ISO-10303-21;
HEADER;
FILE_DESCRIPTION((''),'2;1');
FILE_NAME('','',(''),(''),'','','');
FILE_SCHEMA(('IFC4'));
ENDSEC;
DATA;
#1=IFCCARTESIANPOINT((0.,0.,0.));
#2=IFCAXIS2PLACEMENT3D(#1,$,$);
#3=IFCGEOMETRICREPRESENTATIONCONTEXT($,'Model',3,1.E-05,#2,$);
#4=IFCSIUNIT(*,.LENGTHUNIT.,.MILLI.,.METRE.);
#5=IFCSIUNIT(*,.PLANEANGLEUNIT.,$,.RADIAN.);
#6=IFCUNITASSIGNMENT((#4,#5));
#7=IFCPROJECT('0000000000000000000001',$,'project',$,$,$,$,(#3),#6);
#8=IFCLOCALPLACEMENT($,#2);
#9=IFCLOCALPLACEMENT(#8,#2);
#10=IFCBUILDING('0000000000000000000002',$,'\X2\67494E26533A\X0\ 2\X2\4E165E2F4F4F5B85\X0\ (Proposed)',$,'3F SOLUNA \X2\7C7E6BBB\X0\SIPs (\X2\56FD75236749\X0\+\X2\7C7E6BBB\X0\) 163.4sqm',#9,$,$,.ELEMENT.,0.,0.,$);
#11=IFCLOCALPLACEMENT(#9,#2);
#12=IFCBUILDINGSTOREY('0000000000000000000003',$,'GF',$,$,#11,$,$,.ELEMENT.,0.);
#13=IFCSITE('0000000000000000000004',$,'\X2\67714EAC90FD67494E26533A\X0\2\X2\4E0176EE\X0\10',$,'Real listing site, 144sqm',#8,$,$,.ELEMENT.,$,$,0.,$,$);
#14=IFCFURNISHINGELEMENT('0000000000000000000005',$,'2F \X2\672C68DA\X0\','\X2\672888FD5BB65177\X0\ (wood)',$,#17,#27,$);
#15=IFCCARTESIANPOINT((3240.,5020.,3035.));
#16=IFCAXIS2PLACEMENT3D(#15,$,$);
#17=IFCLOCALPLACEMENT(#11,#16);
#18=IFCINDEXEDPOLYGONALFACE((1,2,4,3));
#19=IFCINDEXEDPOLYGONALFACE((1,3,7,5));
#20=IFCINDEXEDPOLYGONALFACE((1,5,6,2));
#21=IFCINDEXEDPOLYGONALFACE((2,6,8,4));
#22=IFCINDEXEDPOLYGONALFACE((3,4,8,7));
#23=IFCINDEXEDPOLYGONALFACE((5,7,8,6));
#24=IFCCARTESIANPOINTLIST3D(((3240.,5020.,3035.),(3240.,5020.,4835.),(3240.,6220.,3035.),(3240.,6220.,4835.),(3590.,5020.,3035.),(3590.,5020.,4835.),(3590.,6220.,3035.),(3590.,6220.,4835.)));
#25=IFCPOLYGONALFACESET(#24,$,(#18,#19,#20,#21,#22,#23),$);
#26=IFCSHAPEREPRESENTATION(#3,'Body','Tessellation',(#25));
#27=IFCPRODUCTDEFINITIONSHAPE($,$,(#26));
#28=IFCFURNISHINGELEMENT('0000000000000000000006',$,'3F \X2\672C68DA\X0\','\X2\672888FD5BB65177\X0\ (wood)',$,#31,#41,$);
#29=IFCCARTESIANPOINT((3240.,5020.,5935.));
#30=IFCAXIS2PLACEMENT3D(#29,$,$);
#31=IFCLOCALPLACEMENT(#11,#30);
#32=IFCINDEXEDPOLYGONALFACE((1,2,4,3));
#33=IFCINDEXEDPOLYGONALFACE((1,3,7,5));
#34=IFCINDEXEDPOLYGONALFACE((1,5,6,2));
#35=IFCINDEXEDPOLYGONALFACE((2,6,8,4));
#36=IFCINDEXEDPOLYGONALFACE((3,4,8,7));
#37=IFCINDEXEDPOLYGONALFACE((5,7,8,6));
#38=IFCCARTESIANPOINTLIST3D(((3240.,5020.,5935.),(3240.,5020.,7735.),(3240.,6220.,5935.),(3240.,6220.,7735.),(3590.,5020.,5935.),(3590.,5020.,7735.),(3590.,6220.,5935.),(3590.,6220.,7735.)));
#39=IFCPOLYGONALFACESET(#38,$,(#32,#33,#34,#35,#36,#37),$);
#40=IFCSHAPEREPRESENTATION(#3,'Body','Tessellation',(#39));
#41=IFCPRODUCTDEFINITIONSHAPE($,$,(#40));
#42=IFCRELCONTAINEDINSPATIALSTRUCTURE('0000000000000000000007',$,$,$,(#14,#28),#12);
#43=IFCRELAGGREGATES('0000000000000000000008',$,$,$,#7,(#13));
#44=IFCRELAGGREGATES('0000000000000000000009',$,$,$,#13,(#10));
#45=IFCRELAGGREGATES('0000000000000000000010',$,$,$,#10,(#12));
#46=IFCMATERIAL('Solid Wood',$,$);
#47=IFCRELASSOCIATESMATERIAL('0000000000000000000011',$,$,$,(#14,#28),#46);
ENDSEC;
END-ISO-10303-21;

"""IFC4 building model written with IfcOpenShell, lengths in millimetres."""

from ifc_helpers import new_model, si_unit, frame, frame_2d, origin, place, context, project, spatial, rectangle, extrude, material, element, save


model = new_model("IFC4")

# Units and contexts
model_context = context("Model", 3, precision=1e-05, world=origin())
ifc_project = project(units=[si_unit("LENGTHUNIT", "METRE", prefix="MILLI"), si_unit("PLANEANGLEUNIT", "RADIAN")], contexts=[model_context])

# Site, building, storey
site_placement = place(None, origin())
site = spatial("IfcSite", under=ifc_project, at=site_placement, Name="東京都杉並区2丁目10", ObjectType="Real listing site, 144sqm", CompositionType="ELEMENT", RefElevation=0.0)
building_placement = place(site_placement, origin())
building = spatial("IfcBuilding", under=site, at=building_placement, Name="杉並区 2世帯住宅 (Proposed)", ObjectType="3F SOLUNA 籾殻SIPs (国産杉+籾殻) 163.4sqm", CompositionType="ELEMENT", ElevationOfRefHeight=0.0, ElevationOfTerrain=0.0)
storey_placement = place(building_placement, origin())
storey = spatial("IfcBuildingStorey", under=building, at=storey_placement, Name="GF", CompositionType="ELEMENT", Elevation=0.0)

# Shared definitions
ifc_material_1 = material(Name="Solid Wood")

# Furnishing elements
furnishing_1_placement = place(storey_placement, frame((3240.0, 5020.0, 3035.0)))
element("IfcFurnishingElement", 1, at=furnishing_1_placement, inside=storey, material=ifc_material_1, Name="2F 本棚", Description="木製家具 (wood)", context=model_context, shape_type="SweptSolid", body=[
    extrude(rectangle(XDim=350.0, YDim=1200.0, at=frame_2d((175.0, 600.0))), frame((3240.0, 5020.0, 3035.0)), (0.0, 0.0, 1.0), 1800.0),
])
furnishing_2_placement = place(storey_placement, frame((3240.0, 5020.0, 5935.0)))
element("IfcFurnishingElement", 2, at=furnishing_2_placement, inside=storey, material=ifc_material_1, Name="3F 本棚", Description="木製家具 (wood)", context=model_context, shape_type="SweptSolid", body=[
    extrude(rectangle(XDim=350.0, YDim=1200.0, at=frame_2d((175.0, 600.0))), frame((3240.0, 5020.0, 5935.0)), (0.0, 0.0, 1.0), 1800.0),
])

save(model, "model.ifc")
